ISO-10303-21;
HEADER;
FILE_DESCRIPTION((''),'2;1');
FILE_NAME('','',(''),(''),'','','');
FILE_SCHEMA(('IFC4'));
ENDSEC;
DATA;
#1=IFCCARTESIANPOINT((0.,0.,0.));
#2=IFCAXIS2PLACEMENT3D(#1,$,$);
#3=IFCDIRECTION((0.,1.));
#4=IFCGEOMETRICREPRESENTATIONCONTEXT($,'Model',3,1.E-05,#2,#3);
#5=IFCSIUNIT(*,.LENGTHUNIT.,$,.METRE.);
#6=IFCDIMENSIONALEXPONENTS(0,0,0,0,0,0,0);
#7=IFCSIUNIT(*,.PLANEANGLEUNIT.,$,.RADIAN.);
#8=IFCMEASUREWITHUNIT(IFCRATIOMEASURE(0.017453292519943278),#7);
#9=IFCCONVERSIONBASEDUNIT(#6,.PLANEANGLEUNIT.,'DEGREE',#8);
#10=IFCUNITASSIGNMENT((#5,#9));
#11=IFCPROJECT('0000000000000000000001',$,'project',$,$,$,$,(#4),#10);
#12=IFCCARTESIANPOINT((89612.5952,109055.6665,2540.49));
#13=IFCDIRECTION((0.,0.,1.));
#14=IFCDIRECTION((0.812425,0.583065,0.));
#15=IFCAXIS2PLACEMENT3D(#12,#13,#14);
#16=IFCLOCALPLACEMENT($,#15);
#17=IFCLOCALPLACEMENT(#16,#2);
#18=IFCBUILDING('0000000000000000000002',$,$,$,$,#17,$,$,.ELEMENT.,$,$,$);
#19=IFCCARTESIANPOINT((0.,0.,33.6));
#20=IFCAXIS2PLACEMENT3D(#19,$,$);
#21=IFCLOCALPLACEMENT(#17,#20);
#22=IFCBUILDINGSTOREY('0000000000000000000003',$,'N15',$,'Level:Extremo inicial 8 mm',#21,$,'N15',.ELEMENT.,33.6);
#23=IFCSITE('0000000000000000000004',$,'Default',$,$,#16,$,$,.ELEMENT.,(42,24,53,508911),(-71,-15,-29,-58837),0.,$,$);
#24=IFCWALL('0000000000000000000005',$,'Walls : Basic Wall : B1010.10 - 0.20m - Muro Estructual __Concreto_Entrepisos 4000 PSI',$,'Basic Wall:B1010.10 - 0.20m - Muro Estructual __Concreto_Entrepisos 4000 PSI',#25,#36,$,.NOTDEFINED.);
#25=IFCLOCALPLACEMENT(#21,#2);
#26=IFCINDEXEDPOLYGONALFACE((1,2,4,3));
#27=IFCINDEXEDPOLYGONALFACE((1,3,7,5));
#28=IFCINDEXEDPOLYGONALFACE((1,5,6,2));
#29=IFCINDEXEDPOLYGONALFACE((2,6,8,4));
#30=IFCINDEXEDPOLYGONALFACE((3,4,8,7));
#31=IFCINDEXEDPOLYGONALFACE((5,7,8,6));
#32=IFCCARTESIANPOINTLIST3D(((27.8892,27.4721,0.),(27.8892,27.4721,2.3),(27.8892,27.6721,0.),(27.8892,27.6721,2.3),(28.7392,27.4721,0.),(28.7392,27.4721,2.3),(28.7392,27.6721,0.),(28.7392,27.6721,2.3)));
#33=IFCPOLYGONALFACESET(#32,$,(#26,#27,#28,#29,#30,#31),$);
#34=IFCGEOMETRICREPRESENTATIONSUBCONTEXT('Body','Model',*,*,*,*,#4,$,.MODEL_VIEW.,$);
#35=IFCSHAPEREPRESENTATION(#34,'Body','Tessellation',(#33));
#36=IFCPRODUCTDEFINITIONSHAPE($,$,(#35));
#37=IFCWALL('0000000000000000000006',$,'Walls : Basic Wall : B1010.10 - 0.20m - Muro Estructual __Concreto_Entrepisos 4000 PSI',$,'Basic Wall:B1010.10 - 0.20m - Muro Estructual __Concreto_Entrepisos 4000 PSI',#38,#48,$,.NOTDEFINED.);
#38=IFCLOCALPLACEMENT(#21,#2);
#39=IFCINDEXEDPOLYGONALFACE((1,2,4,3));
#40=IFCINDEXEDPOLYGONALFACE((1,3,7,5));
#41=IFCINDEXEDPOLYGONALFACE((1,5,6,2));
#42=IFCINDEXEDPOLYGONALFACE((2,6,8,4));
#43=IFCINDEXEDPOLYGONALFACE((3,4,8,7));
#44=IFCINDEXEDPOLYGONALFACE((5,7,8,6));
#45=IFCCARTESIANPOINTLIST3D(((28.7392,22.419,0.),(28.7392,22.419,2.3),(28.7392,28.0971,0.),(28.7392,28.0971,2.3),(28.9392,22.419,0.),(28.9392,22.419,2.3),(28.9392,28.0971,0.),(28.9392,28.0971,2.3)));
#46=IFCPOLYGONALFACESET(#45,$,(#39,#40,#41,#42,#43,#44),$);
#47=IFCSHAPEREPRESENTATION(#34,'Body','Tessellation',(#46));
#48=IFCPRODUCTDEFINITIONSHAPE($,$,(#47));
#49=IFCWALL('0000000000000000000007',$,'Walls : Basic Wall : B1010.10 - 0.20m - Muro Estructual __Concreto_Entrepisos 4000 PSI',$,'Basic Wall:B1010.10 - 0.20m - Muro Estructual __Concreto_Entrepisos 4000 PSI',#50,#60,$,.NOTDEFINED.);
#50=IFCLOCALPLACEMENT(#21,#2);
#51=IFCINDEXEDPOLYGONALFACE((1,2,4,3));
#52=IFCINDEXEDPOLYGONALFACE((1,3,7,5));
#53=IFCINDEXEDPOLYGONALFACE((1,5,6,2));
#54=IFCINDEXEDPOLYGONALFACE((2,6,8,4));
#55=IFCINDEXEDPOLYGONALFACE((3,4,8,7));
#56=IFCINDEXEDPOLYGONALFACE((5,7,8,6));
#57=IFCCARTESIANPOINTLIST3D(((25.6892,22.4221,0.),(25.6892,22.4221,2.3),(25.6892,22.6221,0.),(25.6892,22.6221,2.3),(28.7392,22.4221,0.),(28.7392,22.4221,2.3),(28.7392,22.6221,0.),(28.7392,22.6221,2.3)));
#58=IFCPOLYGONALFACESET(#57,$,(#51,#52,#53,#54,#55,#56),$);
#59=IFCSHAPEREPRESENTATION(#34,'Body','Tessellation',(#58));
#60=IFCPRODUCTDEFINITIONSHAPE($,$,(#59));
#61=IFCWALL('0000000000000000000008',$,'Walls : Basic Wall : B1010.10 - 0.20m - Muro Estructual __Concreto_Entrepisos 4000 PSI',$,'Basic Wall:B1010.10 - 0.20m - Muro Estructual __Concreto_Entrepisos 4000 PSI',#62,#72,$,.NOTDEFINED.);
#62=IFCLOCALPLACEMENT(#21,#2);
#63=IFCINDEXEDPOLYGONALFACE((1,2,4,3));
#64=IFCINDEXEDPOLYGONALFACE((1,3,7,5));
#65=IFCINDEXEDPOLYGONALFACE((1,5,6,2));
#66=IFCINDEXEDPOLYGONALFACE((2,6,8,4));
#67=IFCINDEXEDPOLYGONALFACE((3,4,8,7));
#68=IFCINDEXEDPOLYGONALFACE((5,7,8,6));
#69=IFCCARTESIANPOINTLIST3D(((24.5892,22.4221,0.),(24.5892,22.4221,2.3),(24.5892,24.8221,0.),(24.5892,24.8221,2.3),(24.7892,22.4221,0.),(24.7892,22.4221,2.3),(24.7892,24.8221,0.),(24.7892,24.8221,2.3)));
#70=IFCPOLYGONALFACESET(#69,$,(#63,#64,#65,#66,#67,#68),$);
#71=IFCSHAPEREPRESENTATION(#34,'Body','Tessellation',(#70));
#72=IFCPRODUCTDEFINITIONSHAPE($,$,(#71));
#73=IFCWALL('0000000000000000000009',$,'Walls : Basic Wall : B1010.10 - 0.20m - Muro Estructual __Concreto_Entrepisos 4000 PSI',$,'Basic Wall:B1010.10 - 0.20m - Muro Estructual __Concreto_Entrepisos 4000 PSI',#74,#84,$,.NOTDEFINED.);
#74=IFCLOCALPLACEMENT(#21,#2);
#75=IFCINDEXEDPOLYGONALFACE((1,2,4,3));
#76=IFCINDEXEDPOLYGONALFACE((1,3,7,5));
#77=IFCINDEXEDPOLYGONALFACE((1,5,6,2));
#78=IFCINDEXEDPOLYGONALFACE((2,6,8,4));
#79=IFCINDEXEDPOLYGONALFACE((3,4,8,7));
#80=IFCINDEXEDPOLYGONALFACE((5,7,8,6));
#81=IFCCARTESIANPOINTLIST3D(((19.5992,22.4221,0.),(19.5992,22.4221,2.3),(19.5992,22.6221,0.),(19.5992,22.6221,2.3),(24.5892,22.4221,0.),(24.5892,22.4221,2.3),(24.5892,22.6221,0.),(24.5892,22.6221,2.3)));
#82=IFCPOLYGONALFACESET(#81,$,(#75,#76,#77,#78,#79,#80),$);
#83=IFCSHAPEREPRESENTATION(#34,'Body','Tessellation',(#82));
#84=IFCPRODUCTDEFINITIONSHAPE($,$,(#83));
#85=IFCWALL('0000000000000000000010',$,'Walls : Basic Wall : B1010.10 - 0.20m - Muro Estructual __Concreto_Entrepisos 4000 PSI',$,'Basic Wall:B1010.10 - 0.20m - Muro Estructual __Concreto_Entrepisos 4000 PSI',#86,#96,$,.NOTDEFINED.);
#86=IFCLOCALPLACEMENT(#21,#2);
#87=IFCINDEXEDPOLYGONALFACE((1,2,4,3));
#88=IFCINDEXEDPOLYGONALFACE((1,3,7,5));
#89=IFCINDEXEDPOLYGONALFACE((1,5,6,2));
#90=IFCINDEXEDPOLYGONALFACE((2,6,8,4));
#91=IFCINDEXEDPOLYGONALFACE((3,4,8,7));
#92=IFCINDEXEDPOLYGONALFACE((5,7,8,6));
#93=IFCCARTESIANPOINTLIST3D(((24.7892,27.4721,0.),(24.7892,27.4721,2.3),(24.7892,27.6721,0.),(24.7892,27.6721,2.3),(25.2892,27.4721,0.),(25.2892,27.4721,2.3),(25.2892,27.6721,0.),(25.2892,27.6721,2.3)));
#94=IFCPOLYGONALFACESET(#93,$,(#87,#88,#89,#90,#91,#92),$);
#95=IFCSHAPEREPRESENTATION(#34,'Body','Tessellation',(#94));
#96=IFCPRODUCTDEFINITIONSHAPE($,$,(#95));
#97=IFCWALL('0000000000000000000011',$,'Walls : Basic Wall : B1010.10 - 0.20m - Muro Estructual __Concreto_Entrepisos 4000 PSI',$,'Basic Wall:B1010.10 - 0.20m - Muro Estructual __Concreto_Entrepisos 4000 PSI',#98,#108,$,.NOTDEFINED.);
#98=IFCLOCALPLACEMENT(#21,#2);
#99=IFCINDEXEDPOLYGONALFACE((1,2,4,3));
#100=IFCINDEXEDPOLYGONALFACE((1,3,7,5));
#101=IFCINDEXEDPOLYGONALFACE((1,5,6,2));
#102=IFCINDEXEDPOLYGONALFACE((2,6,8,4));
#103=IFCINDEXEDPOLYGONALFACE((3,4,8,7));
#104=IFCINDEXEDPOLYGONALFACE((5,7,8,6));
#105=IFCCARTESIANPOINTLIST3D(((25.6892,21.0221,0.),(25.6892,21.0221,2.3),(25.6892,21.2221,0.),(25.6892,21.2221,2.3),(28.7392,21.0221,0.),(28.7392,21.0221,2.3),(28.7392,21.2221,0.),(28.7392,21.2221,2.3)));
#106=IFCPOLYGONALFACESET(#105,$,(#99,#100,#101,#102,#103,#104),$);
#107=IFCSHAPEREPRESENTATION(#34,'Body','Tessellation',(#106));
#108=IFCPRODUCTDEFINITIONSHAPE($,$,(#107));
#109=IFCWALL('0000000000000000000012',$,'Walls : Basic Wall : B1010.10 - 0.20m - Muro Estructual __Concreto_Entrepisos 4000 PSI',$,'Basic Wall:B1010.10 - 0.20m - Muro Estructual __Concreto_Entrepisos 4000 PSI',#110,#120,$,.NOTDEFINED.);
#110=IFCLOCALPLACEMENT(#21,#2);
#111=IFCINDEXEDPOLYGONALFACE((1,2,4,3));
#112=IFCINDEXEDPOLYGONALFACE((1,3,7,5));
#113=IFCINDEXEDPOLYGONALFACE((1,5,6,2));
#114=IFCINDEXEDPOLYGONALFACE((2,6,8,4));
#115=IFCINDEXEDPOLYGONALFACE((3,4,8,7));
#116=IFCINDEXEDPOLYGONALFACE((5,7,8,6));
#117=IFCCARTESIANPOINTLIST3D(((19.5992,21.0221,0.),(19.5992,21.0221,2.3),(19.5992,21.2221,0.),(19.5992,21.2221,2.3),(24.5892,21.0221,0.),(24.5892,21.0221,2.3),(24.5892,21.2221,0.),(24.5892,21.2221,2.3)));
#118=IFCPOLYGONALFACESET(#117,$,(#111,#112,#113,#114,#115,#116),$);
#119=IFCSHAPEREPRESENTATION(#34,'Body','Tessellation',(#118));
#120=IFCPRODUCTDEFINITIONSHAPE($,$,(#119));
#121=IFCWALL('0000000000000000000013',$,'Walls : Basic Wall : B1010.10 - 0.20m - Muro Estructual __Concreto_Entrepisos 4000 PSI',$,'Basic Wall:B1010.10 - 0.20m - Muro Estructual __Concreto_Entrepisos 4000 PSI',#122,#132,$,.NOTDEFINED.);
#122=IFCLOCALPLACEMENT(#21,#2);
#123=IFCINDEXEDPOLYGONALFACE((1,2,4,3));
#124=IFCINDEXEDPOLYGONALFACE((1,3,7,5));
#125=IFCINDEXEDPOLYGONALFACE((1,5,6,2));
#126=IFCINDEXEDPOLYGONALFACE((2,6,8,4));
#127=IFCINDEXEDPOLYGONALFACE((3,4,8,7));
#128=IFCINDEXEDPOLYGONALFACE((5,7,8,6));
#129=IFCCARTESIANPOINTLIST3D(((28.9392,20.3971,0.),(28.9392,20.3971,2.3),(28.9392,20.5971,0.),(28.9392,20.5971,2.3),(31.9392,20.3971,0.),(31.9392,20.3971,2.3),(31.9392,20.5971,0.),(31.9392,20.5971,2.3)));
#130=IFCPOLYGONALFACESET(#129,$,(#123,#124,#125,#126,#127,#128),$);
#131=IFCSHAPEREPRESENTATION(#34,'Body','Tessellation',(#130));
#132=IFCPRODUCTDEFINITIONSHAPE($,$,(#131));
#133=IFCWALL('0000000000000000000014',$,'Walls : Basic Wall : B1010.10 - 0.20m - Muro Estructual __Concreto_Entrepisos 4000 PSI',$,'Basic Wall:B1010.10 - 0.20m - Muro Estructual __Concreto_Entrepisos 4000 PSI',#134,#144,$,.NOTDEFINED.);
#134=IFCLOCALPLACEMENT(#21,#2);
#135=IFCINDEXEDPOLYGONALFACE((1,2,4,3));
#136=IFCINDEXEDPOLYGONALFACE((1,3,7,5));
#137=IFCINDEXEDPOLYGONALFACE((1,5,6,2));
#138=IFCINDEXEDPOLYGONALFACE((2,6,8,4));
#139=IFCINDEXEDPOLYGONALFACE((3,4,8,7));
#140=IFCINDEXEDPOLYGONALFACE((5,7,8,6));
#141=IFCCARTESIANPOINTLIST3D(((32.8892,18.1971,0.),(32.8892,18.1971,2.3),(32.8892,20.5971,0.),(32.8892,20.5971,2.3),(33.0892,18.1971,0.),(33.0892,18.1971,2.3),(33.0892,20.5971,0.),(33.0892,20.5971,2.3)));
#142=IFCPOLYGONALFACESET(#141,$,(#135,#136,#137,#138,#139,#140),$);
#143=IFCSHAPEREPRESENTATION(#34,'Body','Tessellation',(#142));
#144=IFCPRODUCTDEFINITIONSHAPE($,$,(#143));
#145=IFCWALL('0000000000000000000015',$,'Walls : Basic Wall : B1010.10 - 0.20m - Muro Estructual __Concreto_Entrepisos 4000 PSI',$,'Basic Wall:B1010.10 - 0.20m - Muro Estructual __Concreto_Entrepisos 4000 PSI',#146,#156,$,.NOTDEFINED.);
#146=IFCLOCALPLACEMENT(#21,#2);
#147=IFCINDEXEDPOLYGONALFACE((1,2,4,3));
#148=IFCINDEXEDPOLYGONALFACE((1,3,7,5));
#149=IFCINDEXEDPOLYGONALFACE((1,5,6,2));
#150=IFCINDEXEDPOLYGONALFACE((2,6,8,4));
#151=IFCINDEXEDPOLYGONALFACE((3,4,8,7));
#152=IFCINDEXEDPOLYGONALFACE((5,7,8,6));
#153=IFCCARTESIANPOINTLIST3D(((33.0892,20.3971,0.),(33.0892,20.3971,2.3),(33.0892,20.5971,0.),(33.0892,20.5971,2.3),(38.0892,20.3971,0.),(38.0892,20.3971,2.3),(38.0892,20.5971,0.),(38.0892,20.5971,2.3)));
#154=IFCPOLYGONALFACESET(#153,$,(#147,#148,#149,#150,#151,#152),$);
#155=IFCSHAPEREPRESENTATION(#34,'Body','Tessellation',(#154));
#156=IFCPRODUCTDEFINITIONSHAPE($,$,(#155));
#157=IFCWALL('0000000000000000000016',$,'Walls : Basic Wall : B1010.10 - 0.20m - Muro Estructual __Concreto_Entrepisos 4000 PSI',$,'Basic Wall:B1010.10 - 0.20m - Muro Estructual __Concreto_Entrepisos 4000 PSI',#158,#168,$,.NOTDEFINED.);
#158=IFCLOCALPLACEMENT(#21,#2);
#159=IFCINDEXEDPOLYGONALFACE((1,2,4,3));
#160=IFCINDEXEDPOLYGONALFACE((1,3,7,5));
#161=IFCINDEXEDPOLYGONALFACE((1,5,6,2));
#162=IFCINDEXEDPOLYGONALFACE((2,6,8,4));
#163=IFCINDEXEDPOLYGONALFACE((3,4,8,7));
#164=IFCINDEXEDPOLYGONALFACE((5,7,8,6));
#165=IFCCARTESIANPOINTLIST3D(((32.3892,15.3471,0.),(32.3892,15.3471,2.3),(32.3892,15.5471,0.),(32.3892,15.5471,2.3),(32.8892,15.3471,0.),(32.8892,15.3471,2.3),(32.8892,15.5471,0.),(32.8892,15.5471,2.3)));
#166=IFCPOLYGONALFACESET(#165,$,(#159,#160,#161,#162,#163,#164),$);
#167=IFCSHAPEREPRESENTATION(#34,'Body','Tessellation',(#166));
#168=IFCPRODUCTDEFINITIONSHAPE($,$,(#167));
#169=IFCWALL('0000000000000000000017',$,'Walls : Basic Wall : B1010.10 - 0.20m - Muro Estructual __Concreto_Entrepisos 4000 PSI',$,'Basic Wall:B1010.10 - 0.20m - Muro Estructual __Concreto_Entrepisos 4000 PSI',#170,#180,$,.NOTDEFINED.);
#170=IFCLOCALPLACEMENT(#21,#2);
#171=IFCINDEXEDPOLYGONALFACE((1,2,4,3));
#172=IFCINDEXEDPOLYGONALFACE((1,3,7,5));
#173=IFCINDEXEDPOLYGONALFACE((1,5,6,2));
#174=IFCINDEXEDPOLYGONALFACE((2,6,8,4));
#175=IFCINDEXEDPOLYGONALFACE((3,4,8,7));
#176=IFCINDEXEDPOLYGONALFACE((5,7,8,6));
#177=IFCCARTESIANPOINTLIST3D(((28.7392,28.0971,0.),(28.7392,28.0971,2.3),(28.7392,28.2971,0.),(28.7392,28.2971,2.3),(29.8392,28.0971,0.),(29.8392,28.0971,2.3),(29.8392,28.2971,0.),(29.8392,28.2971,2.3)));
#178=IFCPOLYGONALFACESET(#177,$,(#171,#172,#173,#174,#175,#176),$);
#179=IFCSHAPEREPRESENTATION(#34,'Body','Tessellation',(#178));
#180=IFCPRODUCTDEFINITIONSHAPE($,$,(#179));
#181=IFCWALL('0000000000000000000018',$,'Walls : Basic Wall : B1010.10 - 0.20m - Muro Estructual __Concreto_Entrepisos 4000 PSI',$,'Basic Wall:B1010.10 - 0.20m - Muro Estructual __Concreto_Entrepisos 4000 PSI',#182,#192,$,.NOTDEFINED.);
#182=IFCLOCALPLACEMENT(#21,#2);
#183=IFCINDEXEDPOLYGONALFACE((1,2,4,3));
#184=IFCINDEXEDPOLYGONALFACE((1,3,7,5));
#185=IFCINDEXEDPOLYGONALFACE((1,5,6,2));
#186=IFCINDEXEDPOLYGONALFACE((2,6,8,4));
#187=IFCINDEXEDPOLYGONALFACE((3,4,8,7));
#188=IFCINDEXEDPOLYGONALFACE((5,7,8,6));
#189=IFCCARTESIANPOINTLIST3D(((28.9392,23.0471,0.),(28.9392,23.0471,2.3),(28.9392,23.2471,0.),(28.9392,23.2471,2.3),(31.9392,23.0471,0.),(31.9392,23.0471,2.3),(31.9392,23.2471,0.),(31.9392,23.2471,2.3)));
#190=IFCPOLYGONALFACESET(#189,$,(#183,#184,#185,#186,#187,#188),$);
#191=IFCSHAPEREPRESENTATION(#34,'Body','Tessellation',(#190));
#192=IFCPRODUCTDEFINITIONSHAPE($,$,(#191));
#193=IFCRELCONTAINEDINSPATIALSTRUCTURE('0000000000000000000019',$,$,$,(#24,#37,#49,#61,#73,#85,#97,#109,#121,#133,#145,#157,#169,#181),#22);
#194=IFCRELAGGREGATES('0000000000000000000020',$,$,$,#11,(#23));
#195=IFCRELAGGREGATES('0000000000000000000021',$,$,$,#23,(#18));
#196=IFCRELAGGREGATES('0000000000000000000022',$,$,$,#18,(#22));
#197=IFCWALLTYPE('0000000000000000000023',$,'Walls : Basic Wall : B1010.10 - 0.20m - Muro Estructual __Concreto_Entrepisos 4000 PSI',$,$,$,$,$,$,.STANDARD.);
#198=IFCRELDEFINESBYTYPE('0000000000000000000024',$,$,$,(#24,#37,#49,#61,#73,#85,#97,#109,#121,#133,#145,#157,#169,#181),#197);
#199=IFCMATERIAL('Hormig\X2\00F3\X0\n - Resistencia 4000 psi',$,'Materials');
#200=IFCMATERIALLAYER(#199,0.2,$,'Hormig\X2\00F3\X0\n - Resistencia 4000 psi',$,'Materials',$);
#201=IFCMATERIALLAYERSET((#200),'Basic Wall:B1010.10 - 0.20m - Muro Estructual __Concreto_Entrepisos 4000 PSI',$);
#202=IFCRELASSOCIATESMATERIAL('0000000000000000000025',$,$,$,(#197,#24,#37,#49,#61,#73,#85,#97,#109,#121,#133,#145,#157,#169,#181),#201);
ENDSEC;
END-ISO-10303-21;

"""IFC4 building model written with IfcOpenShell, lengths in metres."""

from ifc_helpers import new_model, entity, si_unit, converted_unit, direction, frame, frame_2d, origin, place, context, subcontext, project, spatial, rectangle, extrude, material, layer, layer_set, layer_usage, type_object, element, save


model = new_model("IFC4")

# Units and contexts
model_context = context("Model", 3, precision=1e-05, world=origin(), true_north=direction((0.0, 1.0)))
body_context = subcontext(model_context, "Body", "Model", "MODEL_VIEW")
ifc_project = project(units=[si_unit("LENGTHUNIT", "METRE"), converted_unit("PLANEANGLEUNIT", "DEGREE", entity("IfcRatioMeasure", 0.017453292519943278), si_unit("PLANEANGLEUNIT", "RADIAN"), dimensions=[0, 0, 0, 0, 0, 0, 0])], contexts=[model_context])

# Site, building, storey
site_placement = place(None, frame((89612.5952, 109055.6665, 2540.49), z_axis=(0.0, 0.0, 1.0), x_axis=(0.812425, 0.583065, 0.0)))
site = spatial("IfcSite", under=ifc_project, at=site_placement, Name="Default", CompositionType="ELEMENT", RefLatitude=(42, 24, 53, 508911), RefLongitude=(-71, -15, -29, -58837), RefElevation=0.0)
building_placement = place(site_placement, origin())
building = spatial("IfcBuilding", under=site, at=building_placement, CompositionType="ELEMENT")
storey_placement = place(building_placement, frame((0.0, 0.0, 33.6)))
storey = spatial("IfcBuildingStorey", under=building, at=storey_placement, Name="N15", ObjectType="Level:Extremo inicial 8 mm", LongName="N15", CompositionType="ELEMENT", Elevation=33.6)

# Walls
ifc_material = material(Name="Hormigón - Resistencia 4000 psi", Category="Materials")
ifc_layer_1 = layer(ifc_material, 0.2, Name="Hormigón - Resistencia 4000 psi", Category="Materials")
ifc_layer_set_1 = layer_set([ifc_layer_1], Name="Basic Wall:B1010.10 - 0.20m - Muro Estructual __Concreto_Entrepisos 4000 PSI")
ifc_layer_usage_1 = layer_usage(ifc_layer_set_1, "AXIS2", "NEGATIVE", 0.1)
wall_type_1 = type_object("IfcWallType", Name="Walls : Basic Wall : B1010.10 - 0.20m - Muro Estructual __Concreto_Entrepisos 4000 PSI", PredefinedType="STANDARD", material=ifc_layer_set_1)
wall_1_placement = place(storey_placement, frame((27.8892, 27.5721, 0.0)))
element("IfcWall", 1, at=wall_1_placement, inside=storey, type_object=wall_type_1, material=ifc_layer_usage_1, Name="Walls : Basic Wall : B1010.10 - 0.20m - Muro Estructual __Concreto_Entrepisos 4000 PSI", ObjectType="Basic Wall:B1010.10 - 0.20m - Muro Estructual __Concreto_Entrepisos 4000 PSI", PredefinedType="NOTDEFINED", context=body_context, shape_type="SweptSolid", body=[
    extrude(rectangle(XDim=0.85, YDim=0.2, at=frame_2d((0.425, 0.0), x_axis=(-1.0, 0.0))), origin(), (0.0, 0.0, 1.0), 2.3),
])
ifc_layer_usage_2 = layer_usage(ifc_layer_set_1, "AXIS2", "NEGATIVE", 0.1)
wall_2_placement = place(storey_placement, frame((28.8392, 28.0971, 0.0), z_axis=(0.0, 0.0, 1.0), x_axis=(0.0, -1.0, 0.0)))
element("IfcWall", 2, at=wall_2_placement, inside=storey, type_object=wall_type_1, material=ifc_layer_usage_2, Name="Walls : Basic Wall : B1010.10 - 0.20m - Muro Estructual __Concreto_Entrepisos 4000 PSI", ObjectType="Basic Wall:B1010.10 - 0.20m - Muro Estructual __Concreto_Entrepisos 4000 PSI", PredefinedType="NOTDEFINED", context=body_context, shape_type="SweptSolid", body=[
    extrude(rectangle(XDim=5.6781, YDim=0.2, at=frame_2d((2.839, 0.0), x_axis=(-1.0, 0.0))), origin(), (0.0, 0.0, 1.0), 2.3),
])
ifc_layer_usage_3 = layer_usage(ifc_layer_set_1, "AXIS2", "NEGATIVE", 0.1)
wall_3_placement = place(storey_placement, frame((28.7392, 22.5221, 0.0), z_axis=(0.0, 0.0, 1.0), x_axis=(-1.0, 0.0, 0.0)))
element("IfcWall", 3, at=wall_3_placement, inside=storey, type_object=wall_type_1, material=ifc_layer_usage_3, Name="Walls : Basic Wall : B1010.10 - 0.20m - Muro Estructual __Concreto_Entrepisos 4000 PSI", ObjectType="Basic Wall:B1010.10 - 0.20m - Muro Estructual __Concreto_Entrepisos 4000 PSI", PredefinedType="NOTDEFINED", context=body_context, shape_type="SweptSolid", body=[
    extrude(rectangle(XDim=3.05, YDim=0.2, at=frame_2d((1.525, 0.0), x_axis=(-1.0, 0.0))), origin(), (0.0, 0.0, 1.0), 2.3),
])
ifc_layer_usage_4 = layer_usage(ifc_layer_set_1, "AXIS2", "NEGATIVE", 0.1)
wall_4_placement = place(storey_placement, frame((24.6892, 24.8221, 0.0), z_axis=(0.0, 0.0, 1.0), x_axis=(0.0, -1.0, 0.0)))
element("IfcWall", 4, at=wall_4_placement, inside=storey, type_object=wall_type_1, material=ifc_layer_usage_4, Name="Walls : Basic Wall : B1010.10 - 0.20m - Muro Estructual __Concreto_Entrepisos 4000 PSI", ObjectType="Basic Wall:B1010.10 - 0.20m - Muro Estructual __Concreto_Entrepisos 4000 PSI", PredefinedType="NOTDEFINED", context=body_context, shape_type="SweptSolid", body=[
    extrude(rectangle(XDim=2.4, YDim=0.2, at=frame_2d((1.2, 0.0), x_axis=(-1.0, 0.0))), origin(), (0.0, 0.0, 1.0), 2.3),
])
ifc_layer_usage_5 = layer_usage(ifc_layer_set_1, "AXIS2", "NEGATIVE", 0.1)
wall_5_placement = place(storey_placement, frame((24.5892, 22.5221, 0.0), z_axis=(0.0, 0.0, 1.0), x_axis=(-1.0, 0.0, 0.0)))
element("IfcWall", 5, at=wall_5_placement, inside=storey, type_object=wall_type_1, material=ifc_layer_usage_5, Name="Walls : Basic Wall : B1010.10 - 0.20m - Muro Estructual __Concreto_Entrepisos 4000 PSI", ObjectType="Basic Wall:B1010.10 - 0.20m - Muro Estructual __Concreto_Entrepisos 4000 PSI", PredefinedType="NOTDEFINED", context=body_context, shape_type="SweptSolid", body=[
    extrude(rectangle(XDim=4.99, YDim=0.2, at=frame_2d((2.495, 0.0), x_axis=(-1.0, 0.0))), origin(), (0.0, 0.0, 1.0), 2.3),
])
ifc_layer_usage_6 = layer_usage(ifc_layer_set_1, "AXIS2", "NEGATIVE", 0.1)
wall_6_placement = place(storey_placement, frame((25.2892, 27.5721, 0.0), z_axis=(0.0, 0.0, 1.0), x_axis=(-1.0, 0.0, 0.0)))
element("IfcWall", 6, at=wall_6_placement, inside=storey, type_object=wall_type_1, material=ifc_layer_usage_6, Name="Walls : Basic Wall : B1010.10 - 0.20m - Muro Estructual __Concreto_Entrepisos 4000 PSI", ObjectType="Basic Wall:B1010.10 - 0.20m - Muro Estructual __Concreto_Entrepisos 4000 PSI", PredefinedType="NOTDEFINED", context=body_context, shape_type="SweptSolid", body=[
    extrude(rectangle(XDim=0.5, YDim=0.2, at=frame_2d((0.25, 0.0), x_axis=(-1.0, 0.0))), origin(), (0.0, 0.0, 1.0), 2.3),
])
ifc_layer_usage_7 = layer_usage(ifc_layer_set_1, "AXIS2", "POSITIVE", -0.1)
wall_7_placement = place(storey_placement, frame((28.7392, 21.1221, 0.0), z_axis=(0.0, 0.0, 1.0), x_axis=(-1.0, 0.0, 0.0)))
element("IfcWall", 7, at=wall_7_placement, inside=storey, type_object=wall_type_1, material=ifc_layer_usage_7, Name="Walls : Basic Wall : B1010.10 - 0.20m - Muro Estructual __Concreto_Entrepisos 4000 PSI", ObjectType="Basic Wall:B1010.10 - 0.20m - Muro Estructual __Concreto_Entrepisos 4000 PSI", PredefinedType="NOTDEFINED", context=body_context, shape_type="SweptSolid", body=[
    extrude(rectangle(XDim=3.05, YDim=0.2, at=frame_2d((1.525, 0.0), x_axis=(-1.0, 0.0))), origin(), (0.0, 0.0, 1.0), 2.3),
])
ifc_layer_usage_8 = layer_usage(ifc_layer_set_1, "AXIS2", "POSITIVE", -0.1)
wall_8_placement = place(storey_placement, frame((24.5892, 21.1221, 0.0), z_axis=(0.0, 0.0, 1.0), x_axis=(-1.0, 0.0, 0.0)))
element("IfcWall", 8, at=wall_8_placement, inside=storey, type_object=wall_type_1, material=ifc_layer_usage_8, Name="Walls : Basic Wall : B1010.10 - 0.20m - Muro Estructual __Concreto_Entrepisos 4000 PSI", ObjectType="Basic Wall:B1010.10 - 0.20m - Muro Estructual __Concreto_Entrepisos 4000 PSI", PredefinedType="NOTDEFINED", context=body_context, shape_type="SweptSolid", body=[
    extrude(rectangle(XDim=4.99, YDim=0.2, at=frame_2d((2.495, 0.0), x_axis=(-1.0, 0.0))), origin(), (0.0, 0.0, 1.0), 2.3),
])
ifc_layer_usage_9 = layer_usage(ifc_layer_set_1, "AXIS2", "NEGATIVE", 0.1)
wall_9_placement = place(storey_placement, frame((28.9392, 20.4971, 0.0)))
element("IfcWall", 9, at=wall_9_placement, inside=storey, type_object=wall_type_1, material=ifc_layer_usage_9, Name="Walls : Basic Wall : B1010.10 - 0.20m - Muro Estructual __Concreto_Entrepisos 4000 PSI", ObjectType="Basic Wall:B1010.10 - 0.20m - Muro Estructual __Concreto_Entrepisos 4000 PSI", PredefinedType="NOTDEFINED", context=body_context, shape_type="SweptSolid", body=[
    extrude(rectangle(XDim=3.0, YDim=0.2, at=frame_2d((1.5, 0.0), x_axis=(-1.0, 0.0))), origin(), (0.0, 0.0, 1.0), 2.3),
])
ifc_layer_usage_10 = layer_usage(ifc_layer_set_1, "AXIS2", "NEGATIVE", 0.1)
wall_10_placement = place(storey_placement, frame((32.9892, 18.1971, 0.0), z_axis=(0.0, 0.0, 1.0), x_axis=(0.0, 1.0, 0.0)))
element("IfcWall", 10, at=wall_10_placement, inside=storey, type_object=wall_type_1, material=ifc_layer_usage_10, Name="Walls : Basic Wall : B1010.10 - 0.20m - Muro Estructual __Concreto_Entrepisos 4000 PSI", ObjectType="Basic Wall:B1010.10 - 0.20m - Muro Estructual __Concreto_Entrepisos 4000 PSI", PredefinedType="NOTDEFINED", context=body_context, shape_type="SweptSolid", body=[
    extrude(rectangle(XDim=2.4, YDim=0.2, at=frame_2d((1.2, 0.0), x_axis=(-1.0, 0.0))), origin(), (0.0, 0.0, 1.0), 2.3),
])
ifc_layer_usage_11 = layer_usage(ifc_layer_set_1, "AXIS2", "NEGATIVE", 0.1)
wall_11_placement = place(storey_placement, frame((33.0892, 20.4971, 0.0)))
element("IfcWall", 11, at=wall_11_placement, inside=storey, type_object=wall_type_1, material=ifc_layer_usage_11, Name="Walls : Basic Wall : B1010.10 - 0.20m - Muro Estructual __Concreto_Entrepisos 4000 PSI", ObjectType="Basic Wall:B1010.10 - 0.20m - Muro Estructual __Concreto_Entrepisos 4000 PSI", PredefinedType="NOTDEFINED", context=body_context, shape_type="SweptSolid", body=[
    extrude(rectangle(XDim=5.0, YDim=0.2, at=frame_2d((2.5, 0.0), x_axis=(-1.0, 0.0))), origin(), (0.0, 0.0, 1.0), 2.3),
])
ifc_layer_usage_12 = layer_usage(ifc_layer_set_1, "AXIS2", "NEGATIVE", 0.1)
wall_12_placement = place(storey_placement, frame((32.3892, 15.4471, 0.0)))
element("IfcWall", 12, at=wall_12_placement, inside=storey, type_object=wall_type_1, material=ifc_layer_usage_12, Name="Walls : Basic Wall : B1010.10 - 0.20m - Muro Estructual __Concreto_Entrepisos 4000 PSI", ObjectType="Basic Wall:B1010.10 - 0.20m - Muro Estructual __Concreto_Entrepisos 4000 PSI", PredefinedType="NOTDEFINED", context=body_context, shape_type="SweptSolid", body=[
    extrude(rectangle(XDim=0.5, YDim=0.2, at=frame_2d((0.25, 0.0), x_axis=(-1.0, 0.0))), origin(), (0.0, 0.0, 1.0), 2.3),
])
ifc_layer_usage_13 = layer_usage(ifc_layer_set_1, "AXIS2", "POSITIVE", -0.1)
wall_13_placement = place(storey_placement, frame((29.8392, 28.1971, 0.0), z_axis=(0.0, 0.0, 1.0), x_axis=(-1.0, 0.0, 0.0)))
element("IfcWall", 13, at=wall_13_placement, inside=storey, type_object=wall_type_1, material=ifc_layer_usage_13, Name="Walls : Basic Wall : B1010.10 - 0.20m - Muro Estructual __Concreto_Entrepisos 4000 PSI", ObjectType="Basic Wall:B1010.10 - 0.20m - Muro Estructual __Concreto_Entrepisos 4000 PSI", PredefinedType="NOTDEFINED", context=body_context, shape_type="SweptSolid", body=[
    extrude(rectangle(XDim=1.1, YDim=0.2, at=frame_2d((0.55, 0.0), x_axis=(-1.0, 0.0))), origin(), (0.0, 0.0, 1.0), 2.3),
])
ifc_layer_usage_14 = layer_usage(ifc_layer_set_1, "AXIS2", "POSITIVE", -0.1)
wall_14_placement = place(storey_placement, frame((28.9392, 23.1471, 0.0)))
element("IfcWall", 14, at=wall_14_placement, inside=storey, type_object=wall_type_1, material=ifc_layer_usage_14, Name="Walls : Basic Wall : B1010.10 - 0.20m - Muro Estructual __Concreto_Entrepisos 4000 PSI", ObjectType="Basic Wall:B1010.10 - 0.20m - Muro Estructual __Concreto_Entrepisos 4000 PSI", PredefinedType="NOTDEFINED", context=body_context, shape_type="SweptSolid", body=[
    extrude(rectangle(XDim=3.0, YDim=0.2, at=frame_2d((1.5, 0.0), x_axis=(-1.0, 0.0))), origin(), (0.0, 0.0, 1.0), 2.3),
])

save(model, "model.ifc")
